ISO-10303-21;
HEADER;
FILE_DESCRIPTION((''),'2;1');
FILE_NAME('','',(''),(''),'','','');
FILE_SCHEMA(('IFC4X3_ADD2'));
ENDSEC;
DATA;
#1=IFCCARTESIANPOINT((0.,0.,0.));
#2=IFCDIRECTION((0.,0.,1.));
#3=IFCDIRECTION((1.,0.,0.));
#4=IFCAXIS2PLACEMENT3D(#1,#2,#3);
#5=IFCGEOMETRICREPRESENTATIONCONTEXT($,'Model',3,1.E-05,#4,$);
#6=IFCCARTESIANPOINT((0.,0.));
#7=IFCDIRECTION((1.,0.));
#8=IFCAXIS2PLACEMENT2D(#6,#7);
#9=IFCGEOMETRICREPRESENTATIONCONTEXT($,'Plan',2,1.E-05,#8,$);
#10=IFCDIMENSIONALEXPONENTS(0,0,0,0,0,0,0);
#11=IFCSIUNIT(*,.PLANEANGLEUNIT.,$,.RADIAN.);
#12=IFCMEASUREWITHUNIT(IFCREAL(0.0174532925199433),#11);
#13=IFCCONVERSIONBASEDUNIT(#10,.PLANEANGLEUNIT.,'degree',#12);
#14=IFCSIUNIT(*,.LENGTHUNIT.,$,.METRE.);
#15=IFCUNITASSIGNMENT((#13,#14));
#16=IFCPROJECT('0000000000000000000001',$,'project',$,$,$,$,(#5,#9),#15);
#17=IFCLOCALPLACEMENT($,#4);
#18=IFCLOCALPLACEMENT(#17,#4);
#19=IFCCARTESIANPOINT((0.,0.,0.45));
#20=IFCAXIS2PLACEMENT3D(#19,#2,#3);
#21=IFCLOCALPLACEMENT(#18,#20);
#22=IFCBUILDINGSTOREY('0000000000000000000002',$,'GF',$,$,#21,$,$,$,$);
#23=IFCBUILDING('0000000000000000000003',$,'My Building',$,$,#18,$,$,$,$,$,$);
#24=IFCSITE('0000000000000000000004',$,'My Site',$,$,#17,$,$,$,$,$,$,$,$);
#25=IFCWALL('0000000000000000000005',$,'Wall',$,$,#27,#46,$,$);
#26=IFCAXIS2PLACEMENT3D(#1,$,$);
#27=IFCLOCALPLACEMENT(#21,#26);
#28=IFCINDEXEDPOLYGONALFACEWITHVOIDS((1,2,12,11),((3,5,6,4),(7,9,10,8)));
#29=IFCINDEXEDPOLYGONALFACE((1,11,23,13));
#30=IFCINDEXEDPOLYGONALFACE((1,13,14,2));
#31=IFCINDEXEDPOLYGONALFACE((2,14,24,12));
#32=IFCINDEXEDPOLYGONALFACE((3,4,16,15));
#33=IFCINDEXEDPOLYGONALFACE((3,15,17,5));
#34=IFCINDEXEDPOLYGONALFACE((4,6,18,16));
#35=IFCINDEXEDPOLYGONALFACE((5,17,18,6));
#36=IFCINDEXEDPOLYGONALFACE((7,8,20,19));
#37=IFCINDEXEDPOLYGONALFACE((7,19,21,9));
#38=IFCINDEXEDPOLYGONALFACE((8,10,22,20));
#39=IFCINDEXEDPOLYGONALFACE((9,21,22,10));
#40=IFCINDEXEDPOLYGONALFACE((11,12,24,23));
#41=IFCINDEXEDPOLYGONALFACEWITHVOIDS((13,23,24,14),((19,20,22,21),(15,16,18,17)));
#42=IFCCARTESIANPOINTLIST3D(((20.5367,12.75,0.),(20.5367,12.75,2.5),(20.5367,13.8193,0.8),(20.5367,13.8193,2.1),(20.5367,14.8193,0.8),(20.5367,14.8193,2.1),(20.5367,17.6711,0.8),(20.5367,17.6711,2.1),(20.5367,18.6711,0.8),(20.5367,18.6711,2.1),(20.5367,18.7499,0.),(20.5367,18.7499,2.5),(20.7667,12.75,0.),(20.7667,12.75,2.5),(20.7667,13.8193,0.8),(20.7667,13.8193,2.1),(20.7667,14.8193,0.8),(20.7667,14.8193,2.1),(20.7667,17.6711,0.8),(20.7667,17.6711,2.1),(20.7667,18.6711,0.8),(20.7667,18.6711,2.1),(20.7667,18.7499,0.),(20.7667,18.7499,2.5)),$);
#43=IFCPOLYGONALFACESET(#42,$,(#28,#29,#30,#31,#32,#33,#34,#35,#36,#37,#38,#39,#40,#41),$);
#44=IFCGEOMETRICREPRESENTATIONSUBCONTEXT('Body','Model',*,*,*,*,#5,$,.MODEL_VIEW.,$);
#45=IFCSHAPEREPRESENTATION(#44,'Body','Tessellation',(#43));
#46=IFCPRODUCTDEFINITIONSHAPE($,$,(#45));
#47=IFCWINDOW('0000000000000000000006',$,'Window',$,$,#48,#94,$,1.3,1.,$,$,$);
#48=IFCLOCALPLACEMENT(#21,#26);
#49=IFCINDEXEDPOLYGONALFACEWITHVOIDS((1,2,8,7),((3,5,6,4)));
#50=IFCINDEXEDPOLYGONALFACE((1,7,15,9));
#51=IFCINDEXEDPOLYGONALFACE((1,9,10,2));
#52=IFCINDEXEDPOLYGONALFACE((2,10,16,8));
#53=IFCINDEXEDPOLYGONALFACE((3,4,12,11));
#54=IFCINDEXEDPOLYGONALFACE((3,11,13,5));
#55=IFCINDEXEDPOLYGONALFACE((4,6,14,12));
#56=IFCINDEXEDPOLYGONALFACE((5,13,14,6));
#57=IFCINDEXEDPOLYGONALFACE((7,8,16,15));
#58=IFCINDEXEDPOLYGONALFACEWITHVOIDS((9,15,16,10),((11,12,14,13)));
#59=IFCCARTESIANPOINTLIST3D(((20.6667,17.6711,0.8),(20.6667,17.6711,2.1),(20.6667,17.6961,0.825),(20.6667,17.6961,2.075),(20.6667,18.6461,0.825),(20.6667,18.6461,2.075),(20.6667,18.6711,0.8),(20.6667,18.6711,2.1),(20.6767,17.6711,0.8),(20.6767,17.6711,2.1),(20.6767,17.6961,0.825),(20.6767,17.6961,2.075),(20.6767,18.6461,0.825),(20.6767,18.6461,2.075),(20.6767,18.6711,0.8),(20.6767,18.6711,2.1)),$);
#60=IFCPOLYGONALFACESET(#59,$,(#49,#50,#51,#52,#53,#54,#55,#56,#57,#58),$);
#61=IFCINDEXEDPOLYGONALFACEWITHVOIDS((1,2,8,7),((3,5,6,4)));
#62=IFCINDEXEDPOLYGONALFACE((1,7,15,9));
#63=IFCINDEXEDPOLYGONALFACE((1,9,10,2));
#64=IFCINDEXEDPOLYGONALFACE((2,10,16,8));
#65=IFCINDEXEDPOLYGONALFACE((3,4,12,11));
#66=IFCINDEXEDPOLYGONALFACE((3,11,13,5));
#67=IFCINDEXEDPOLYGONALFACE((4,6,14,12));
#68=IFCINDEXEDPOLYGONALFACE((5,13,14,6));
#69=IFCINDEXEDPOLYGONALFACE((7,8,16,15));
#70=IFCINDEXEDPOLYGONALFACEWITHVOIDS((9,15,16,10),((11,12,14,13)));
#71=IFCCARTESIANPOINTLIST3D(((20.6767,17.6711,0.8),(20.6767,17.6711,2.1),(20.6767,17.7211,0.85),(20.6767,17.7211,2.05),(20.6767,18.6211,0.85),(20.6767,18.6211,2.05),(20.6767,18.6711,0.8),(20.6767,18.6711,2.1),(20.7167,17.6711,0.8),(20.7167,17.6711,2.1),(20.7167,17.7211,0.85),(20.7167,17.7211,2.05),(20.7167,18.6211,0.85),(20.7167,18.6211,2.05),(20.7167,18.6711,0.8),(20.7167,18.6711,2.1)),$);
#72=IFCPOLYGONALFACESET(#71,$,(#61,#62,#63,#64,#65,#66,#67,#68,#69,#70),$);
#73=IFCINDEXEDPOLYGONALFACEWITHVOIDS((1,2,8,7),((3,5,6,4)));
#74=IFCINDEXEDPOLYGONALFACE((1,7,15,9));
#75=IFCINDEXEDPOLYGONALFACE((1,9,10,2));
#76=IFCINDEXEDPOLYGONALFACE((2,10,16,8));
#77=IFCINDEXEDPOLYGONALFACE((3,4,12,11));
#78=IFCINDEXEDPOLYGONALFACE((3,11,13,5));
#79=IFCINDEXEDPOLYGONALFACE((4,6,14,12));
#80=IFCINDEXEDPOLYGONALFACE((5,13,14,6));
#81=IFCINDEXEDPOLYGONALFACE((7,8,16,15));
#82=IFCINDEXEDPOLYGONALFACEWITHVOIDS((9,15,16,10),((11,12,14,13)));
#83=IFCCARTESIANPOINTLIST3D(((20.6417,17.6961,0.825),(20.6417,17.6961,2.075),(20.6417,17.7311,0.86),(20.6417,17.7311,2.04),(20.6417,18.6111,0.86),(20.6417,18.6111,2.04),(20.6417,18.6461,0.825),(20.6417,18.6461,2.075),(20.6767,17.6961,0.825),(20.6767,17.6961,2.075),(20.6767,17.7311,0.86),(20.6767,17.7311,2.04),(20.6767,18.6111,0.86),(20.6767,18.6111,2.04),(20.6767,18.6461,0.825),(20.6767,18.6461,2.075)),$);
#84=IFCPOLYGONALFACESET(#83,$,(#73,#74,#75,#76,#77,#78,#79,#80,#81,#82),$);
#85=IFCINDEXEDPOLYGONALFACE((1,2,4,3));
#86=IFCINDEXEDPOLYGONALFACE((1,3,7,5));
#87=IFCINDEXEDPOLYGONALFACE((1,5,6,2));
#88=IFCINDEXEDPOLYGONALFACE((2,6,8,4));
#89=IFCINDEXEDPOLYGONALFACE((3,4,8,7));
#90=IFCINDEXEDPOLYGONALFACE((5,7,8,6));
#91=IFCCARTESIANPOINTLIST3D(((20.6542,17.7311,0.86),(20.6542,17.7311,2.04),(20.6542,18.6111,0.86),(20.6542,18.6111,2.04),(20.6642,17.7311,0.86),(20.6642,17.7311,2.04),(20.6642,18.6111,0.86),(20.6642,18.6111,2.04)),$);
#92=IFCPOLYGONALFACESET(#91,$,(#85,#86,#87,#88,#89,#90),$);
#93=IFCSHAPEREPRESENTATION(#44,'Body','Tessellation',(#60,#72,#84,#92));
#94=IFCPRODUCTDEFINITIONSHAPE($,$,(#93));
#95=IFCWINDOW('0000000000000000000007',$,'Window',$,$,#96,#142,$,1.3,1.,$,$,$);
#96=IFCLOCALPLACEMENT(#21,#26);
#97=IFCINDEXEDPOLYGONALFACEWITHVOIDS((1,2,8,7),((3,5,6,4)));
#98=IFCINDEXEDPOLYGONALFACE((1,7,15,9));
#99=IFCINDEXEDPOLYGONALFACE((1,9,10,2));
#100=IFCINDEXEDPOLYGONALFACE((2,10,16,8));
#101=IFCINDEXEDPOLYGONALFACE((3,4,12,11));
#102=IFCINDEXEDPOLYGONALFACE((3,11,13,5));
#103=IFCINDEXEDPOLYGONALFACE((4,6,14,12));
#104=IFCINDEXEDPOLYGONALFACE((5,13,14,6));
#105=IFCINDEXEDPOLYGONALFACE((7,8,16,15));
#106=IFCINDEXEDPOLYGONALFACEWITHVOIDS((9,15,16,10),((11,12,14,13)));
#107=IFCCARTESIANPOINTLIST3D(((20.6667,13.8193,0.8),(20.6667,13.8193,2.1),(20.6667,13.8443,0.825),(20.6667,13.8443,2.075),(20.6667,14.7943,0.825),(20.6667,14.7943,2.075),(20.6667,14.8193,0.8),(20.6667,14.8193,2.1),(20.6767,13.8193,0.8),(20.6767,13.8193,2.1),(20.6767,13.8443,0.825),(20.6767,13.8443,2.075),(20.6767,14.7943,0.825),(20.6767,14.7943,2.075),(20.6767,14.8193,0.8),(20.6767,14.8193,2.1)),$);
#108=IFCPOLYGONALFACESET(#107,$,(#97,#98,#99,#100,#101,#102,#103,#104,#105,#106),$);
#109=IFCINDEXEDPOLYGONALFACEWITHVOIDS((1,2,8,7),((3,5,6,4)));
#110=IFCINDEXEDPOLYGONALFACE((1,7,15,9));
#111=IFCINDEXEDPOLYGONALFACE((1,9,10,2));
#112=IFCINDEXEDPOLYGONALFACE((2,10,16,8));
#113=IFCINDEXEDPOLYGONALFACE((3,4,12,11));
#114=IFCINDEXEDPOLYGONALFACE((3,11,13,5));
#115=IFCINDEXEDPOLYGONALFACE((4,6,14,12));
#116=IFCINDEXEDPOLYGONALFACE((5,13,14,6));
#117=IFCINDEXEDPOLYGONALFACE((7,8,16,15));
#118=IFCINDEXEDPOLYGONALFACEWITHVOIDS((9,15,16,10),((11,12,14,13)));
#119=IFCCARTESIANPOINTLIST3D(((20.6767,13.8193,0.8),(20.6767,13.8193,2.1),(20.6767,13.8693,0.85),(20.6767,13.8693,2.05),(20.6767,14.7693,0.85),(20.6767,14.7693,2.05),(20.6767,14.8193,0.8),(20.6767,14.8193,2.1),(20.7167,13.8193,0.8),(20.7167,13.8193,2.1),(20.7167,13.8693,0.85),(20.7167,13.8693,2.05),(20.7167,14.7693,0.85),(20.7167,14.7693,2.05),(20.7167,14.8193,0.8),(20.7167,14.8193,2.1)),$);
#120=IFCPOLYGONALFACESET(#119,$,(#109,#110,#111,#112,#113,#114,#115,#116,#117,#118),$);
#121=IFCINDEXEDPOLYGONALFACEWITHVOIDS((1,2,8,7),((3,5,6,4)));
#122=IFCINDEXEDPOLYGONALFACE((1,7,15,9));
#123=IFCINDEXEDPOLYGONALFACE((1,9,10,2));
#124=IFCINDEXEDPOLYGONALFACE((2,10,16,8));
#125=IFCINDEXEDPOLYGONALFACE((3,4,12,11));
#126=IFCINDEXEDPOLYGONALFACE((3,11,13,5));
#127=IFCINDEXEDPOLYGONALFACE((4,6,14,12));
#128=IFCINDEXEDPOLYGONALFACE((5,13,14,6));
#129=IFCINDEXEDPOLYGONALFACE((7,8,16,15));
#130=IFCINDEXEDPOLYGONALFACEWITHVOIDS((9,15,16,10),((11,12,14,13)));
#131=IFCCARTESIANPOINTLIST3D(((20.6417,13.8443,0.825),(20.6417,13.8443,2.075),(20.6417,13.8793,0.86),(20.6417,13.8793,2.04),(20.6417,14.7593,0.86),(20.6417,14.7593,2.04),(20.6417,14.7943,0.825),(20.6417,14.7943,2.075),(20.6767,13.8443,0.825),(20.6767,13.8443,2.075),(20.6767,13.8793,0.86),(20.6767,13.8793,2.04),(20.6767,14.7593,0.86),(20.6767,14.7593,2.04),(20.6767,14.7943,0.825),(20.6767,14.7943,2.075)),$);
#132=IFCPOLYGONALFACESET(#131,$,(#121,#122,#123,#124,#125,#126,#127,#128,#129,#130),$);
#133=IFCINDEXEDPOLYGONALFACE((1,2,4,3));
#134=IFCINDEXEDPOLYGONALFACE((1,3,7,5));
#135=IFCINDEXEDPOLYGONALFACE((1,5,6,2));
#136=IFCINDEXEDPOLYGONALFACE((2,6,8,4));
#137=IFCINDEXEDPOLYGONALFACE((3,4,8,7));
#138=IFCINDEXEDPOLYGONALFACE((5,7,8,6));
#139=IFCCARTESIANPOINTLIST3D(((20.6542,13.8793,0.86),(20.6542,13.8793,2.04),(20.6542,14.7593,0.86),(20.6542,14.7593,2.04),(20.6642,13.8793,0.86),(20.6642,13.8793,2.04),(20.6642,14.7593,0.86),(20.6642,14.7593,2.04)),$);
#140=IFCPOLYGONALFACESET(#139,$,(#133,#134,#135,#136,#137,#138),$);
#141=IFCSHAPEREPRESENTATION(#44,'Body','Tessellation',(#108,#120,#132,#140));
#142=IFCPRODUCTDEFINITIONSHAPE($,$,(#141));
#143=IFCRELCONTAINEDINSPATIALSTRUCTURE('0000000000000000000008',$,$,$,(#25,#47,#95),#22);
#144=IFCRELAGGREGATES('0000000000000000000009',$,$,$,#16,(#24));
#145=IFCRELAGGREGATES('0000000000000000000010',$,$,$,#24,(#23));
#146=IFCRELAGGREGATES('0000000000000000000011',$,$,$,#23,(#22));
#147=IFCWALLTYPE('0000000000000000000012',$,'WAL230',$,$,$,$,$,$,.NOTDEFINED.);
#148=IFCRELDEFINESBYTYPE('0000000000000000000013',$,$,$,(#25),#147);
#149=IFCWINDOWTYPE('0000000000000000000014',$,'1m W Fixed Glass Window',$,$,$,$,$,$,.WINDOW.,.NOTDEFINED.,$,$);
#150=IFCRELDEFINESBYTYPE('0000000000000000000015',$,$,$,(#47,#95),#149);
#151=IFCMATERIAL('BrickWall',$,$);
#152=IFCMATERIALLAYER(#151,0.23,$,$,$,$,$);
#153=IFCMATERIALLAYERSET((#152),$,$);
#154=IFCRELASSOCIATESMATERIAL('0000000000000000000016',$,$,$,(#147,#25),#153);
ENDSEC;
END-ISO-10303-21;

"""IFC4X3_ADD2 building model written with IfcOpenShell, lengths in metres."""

from ifc_helpers import new_model, entity, si_unit, converted_unit, frame, origin_with_axes, origin_2d_with_axis, place, context, subcontext, project, spatial, line, indexed_curve, outline, extrude, shape, source, transform, mapped, material, layer, layer_set, layer_usage, type_object, type_shapes, element, fill, save


model = new_model("IFC4X3_ADD2")

# Units and contexts
model_context = context("Model", 3, precision=1e-05, world=origin_with_axes())
plan_context = context("Plan", 2, precision=1e-05, world=origin_2d_with_axis())
body_context_1 = subcontext(model_context, "Body", "Model", "MODEL_VIEW")
body_context_2 = subcontext(plan_context, "Body", "Plan", "PLAN_VIEW")
ifc_project = project(units=[converted_unit("PLANEANGLEUNIT", "degree", entity("IfcReal", 0.0174532925199433), si_unit("PLANEANGLEUNIT", "RADIAN"), dimensions=[0, 0, 0, 0, 0, 0, 0]), si_unit("LENGTHUNIT", "METRE")], contexts=[model_context, plan_context])

# Site, building, storey
site_placement = place(None, origin_with_axes())
site = spatial("IfcSite", under=ifc_project, at=site_placement, Name="My Site")
building_placement = place(site_placement, origin_with_axes())
building = spatial("IfcBuilding", under=site, at=building_placement, Name="My Building")
storey_placement = place(building_placement, frame((0.0, 0.0, 0.45), z_axis=(0.0, 0.0, 1.0), x_axis=(1.0, 0.0, 0.0)))
storey = spatial("IfcBuildingStorey", under=building, at=storey_placement, Name="GF")

# Shared definitions
ifc_material_1 = material(Name="BrickWall")
ifc_layer_1 = layer(ifc_material_1, 0.23)
ifc_layer_set_1 = layer_set([ifc_layer_1])
wall_type_1 = type_object("IfcWallType", Name="WAL230", PredefinedType="NOTDEFINED", material=ifc_layer_set_1)

# Wall, openings, windows
ifc_layer_usage_1 = layer_usage(ifc_layer_set_1, "AXIS2", "POSITIVE", 0.0)
wall_1_placement = place(storey_placement, frame((20.7667, 12.75, 0.0), z_axis=(0.0, 0.0, 1.0), x_axis=(0.0, 1.0, 0.0)))
wall_1 = element("IfcWall", 1, at=wall_1_placement, inside=storey, type_object=wall_type_1, material=ifc_layer_usage_1, Name="Wall", context=body_context_1, shape_type="SweptSolid", body=[
    extrude(outline(indexed_curve([(0.0, 0.0), (0.0, 0.23), (5.9999, 0.23), (5.9999, 0.0), (0.0, 0.0)], self_intersect=False)), origin_with_axes(), (0.0, 0.0, 1.0), 2.5),
])
shared_shape_1 = source(origin_with_axes(), body_context_1, "Body", "SweptSolid", [
    extrude(outline(indexed_curve([(0.0, 0.0), (1.0, 0.0), (1.0, 1.3), (0.0, 1.3)], segments=[line(1, 2, 3, 4, 1)])), frame((0.0, -0.6, 0.0), z_axis=(0.0, -1.0, 0.0), x_axis=(1.0, 0.0, 0.0)), (0.0, 0.0, -1.0), 1.2),
])
opening_1_placement = place(wall_1_placement, frame((4.9211, 0.0, 0.8), z_axis=(0.0, 0.0, 1.0), x_axis=(1.0, 0.0, 0.0)))
opening_1 = element("IfcOpeningElement", 2, at=opening_1_placement, cuts=wall_1, PredefinedType="OPENING", context=body_context_1, shape_type="MappedRepresentation", body=[
    mapped(shared_shape_1, transform((0.0, 0.0, 0.0), x_axis=(1.0, 0.0, 0.0), y_axis=(0.0, 1.0, 0.0), z_axis=(0.0, 0.0, 1.0), scale=1.0)),
])
opening_2_placement = place(wall_1_placement, frame((1.0693, 0.0, 0.8), z_axis=(0.0, 0.0, 1.0), x_axis=(1.0, 0.0, 0.0)))
opening_2 = element("IfcOpeningElement", 3, at=opening_2_placement, cuts=wall_1, PredefinedType="OPENING", context=body_context_1, shape_type="MappedRepresentation", body=[
    mapped(shared_shape_1, transform((0.0, 0.0, 0.0), x_axis=(1.0, 0.0, 0.0), y_axis=(0.0, 1.0, 0.0), z_axis=(0.0, 0.0, 1.0), scale=1.0)),
])
window_type_1 = type_object("IfcWindowType", Name="1m W Fixed Glass Window", PartitioningType="NOTDEFINED", PredefinedType="WINDOW")
shared_shape_2 = source(origin_with_axes(), body_context_1, "Body", "SweptSolid", [
    extrude(outline(indexed_curve([(0.0, 0.0), (1.0, 0.0), (1.0, 1.3), (0.0, 1.3)], segments=[line(1, 2, 3, 4, 1)]), holes=[indexed_curve([(0.025, 0.025), (0.975, 0.025), (0.975, 1.275), (0.025, 1.275)], segments=[line(1, 2, 3, 4, 1)])]), frame((0.0, 0.09, 0.0), z_axis=(0.0, -1.0, 0.0), x_axis=(1.0, 0.0, 0.0)), (0.0, 0.0, -1.0), 0.01),
    extrude(outline(indexed_curve([(0.0, 0.0), (1.0, 0.0), (1.0, 1.3), (0.0, 1.3)], segments=[line(1, 2, 3, 4, 1)]), holes=[indexed_curve([(0.05, 0.05), (0.95, 0.05), (0.95, 1.25), (0.05, 1.25)], segments=[line(1, 2, 3, 4, 1)])]), frame((0.0, 0.05, 0.0), z_axis=(0.0, -1.0, 0.0), x_axis=(1.0, 0.0, 0.0)), (0.0, 0.0, -1.0), 0.04),
    extrude(outline(indexed_curve([(0.0, 0.0), (0.95, 0.0), (0.95, 1.25), (0.0, 1.25)], segments=[line(1, 2, 3, 4, 1)]), holes=[indexed_curve([(0.035, 0.035), (0.915, 0.035), (0.915, 1.215), (0.035, 1.215)], segments=[line(1, 2, 3, 4, 1)])]), frame((0.025, 0.09, 0.025), z_axis=(0.0, -1.0, 0.0), x_axis=(1.0, 0.0, 0.0)), (0.0, 0.0, -1.0), 0.035),
    extrude(outline(indexed_curve([(0.035, 0.035), (0.915, 0.035), (0.915, 1.215), (0.035, 1.215)], segments=[line(1, 2, 3, 4, 1)])), frame((0.025, 0.1025, 0.025), z_axis=(0.0, -1.0, 0.0), x_axis=(1.0, 0.0, 0.0)), (0.0, 0.0, -1.0), 0.01),
])
shared_shape_3 = source(origin_with_axes(), body_context_2, "Body", "Curve2D", [
    entity("IfcIndexedPolyCurve", entity("IfcCartesianPointList2D", [[0.05, 0.05], [0.95, 0.05]])),
    entity("IfcIndexedPolyCurve", entity("IfcCartesianPointList2D", [[0.0, 0.1], [0.025, 0.1], [0.025, 0.09], [0.05, 0.09], [0.05, 0.05], [0.0, 0.05]]), [entity("IfcLineIndex", [1, 2, 3, 4, 5, 6, 1])]),
    entity("IfcIndexedPolyCurve", entity("IfcCartesianPointList2D", [[1.0, 0.1], [0.975, 0.1], [0.975, 0.09], [0.95, 0.09], [0.95, 0.05], [1.0, 0.05]]), [entity("IfcLineIndex", [1, 2, 3, 4, 5, 6, 1])]),
    entity("IfcIndexedPolyCurve", entity("IfcCartesianPointList2D", [[0.025, 0.09], [0.06, 0.09], [0.06, 0.125], [0.025, 0.125]]), [entity("IfcLineIndex", [1, 2, 3, 4, 1])]),
    entity("IfcIndexedPolyCurve", entity("IfcCartesianPointList2D", [[0.975, 0.09], [0.94, 0.09], [0.94, 0.125], [0.975, 0.125]]), [entity("IfcLineIndex", [1, 2, 3, 4, 1])]),
    entity("IfcIndexedPolyCurve", entity("IfcCartesianPointList2D", [[0.06, 0.09], [0.94, 0.09]])),
    entity("IfcIndexedPolyCurve", entity("IfcCartesianPointList2D", [[0.06, 0.125], [0.94, 0.125]])),
    entity("IfcIndexedPolyCurve", entity("IfcCartesianPointList2D", [[0.06, 0.1075], [0.94, 0.1075]])),
])
type_shapes(window_type_1, [shared_shape_2, shared_shape_3])
window_1_placement = place(opening_1_placement, frame((0.0, 0.0, 0.0), z_axis=(0.0, 0.0, 1.0), x_axis=(1.0, 0.0, 0.0)))
window_1 = element("IfcWindow", 4, at=window_1_placement, inside=storey, type_object=window_type_1, Name="Window", OverallHeight=1.3, OverallWidth=1.0, shapes=[
    shape(body_context_1, "Body", "MappedRepresentation", [mapped(shared_shape_2, transform((0.0, 0.0, 0.0), x_axis=(1.0, 0.0, 0.0), y_axis=(0.0, 1.0, 0.0), z_axis=(0.0, 0.0, 1.0), scale=1.0))]),
    shape(body_context_2, "Body", "MappedRepresentation", [mapped(shared_shape_3, transform((0.0, 0.0, 0.0), x_axis=(1.0, 0.0, 0.0), y_axis=(0.0, 1.0, 0.0), z_axis=(0.0, 0.0, 1.0), scale=1.0))]),
])
fill(opening_1, window_1)
window_2_placement = place(opening_2_placement, frame((0.0, 0.0, 0.0), z_axis=(0.0, 0.0, 1.0), x_axis=(1.0, 0.0, 0.0)))
window_2 = element("IfcWindow", 5, at=window_2_placement, inside=storey, type_object=window_type_1, Name="Window", OverallHeight=1.3, OverallWidth=1.0, shapes=[
    shape(body_context_1, "Body", "MappedRepresentation", [mapped(shared_shape_2, transform((0.0, 0.0, 0.0), x_axis=(1.0, 0.0, 0.0), y_axis=(0.0, 1.0, 0.0), z_axis=(0.0, 0.0, 1.0), scale=1.0))]),
    shape(body_context_2, "Body", "MappedRepresentation", [mapped(shared_shape_3, transform((0.0, 0.0, 0.0), x_axis=(1.0, 0.0, 0.0), y_axis=(0.0, 1.0, 0.0), z_axis=(0.0, 0.0, 1.0), scale=1.0))]),
])
fill(opening_2, window_2)

save(model, "model.ifc")
